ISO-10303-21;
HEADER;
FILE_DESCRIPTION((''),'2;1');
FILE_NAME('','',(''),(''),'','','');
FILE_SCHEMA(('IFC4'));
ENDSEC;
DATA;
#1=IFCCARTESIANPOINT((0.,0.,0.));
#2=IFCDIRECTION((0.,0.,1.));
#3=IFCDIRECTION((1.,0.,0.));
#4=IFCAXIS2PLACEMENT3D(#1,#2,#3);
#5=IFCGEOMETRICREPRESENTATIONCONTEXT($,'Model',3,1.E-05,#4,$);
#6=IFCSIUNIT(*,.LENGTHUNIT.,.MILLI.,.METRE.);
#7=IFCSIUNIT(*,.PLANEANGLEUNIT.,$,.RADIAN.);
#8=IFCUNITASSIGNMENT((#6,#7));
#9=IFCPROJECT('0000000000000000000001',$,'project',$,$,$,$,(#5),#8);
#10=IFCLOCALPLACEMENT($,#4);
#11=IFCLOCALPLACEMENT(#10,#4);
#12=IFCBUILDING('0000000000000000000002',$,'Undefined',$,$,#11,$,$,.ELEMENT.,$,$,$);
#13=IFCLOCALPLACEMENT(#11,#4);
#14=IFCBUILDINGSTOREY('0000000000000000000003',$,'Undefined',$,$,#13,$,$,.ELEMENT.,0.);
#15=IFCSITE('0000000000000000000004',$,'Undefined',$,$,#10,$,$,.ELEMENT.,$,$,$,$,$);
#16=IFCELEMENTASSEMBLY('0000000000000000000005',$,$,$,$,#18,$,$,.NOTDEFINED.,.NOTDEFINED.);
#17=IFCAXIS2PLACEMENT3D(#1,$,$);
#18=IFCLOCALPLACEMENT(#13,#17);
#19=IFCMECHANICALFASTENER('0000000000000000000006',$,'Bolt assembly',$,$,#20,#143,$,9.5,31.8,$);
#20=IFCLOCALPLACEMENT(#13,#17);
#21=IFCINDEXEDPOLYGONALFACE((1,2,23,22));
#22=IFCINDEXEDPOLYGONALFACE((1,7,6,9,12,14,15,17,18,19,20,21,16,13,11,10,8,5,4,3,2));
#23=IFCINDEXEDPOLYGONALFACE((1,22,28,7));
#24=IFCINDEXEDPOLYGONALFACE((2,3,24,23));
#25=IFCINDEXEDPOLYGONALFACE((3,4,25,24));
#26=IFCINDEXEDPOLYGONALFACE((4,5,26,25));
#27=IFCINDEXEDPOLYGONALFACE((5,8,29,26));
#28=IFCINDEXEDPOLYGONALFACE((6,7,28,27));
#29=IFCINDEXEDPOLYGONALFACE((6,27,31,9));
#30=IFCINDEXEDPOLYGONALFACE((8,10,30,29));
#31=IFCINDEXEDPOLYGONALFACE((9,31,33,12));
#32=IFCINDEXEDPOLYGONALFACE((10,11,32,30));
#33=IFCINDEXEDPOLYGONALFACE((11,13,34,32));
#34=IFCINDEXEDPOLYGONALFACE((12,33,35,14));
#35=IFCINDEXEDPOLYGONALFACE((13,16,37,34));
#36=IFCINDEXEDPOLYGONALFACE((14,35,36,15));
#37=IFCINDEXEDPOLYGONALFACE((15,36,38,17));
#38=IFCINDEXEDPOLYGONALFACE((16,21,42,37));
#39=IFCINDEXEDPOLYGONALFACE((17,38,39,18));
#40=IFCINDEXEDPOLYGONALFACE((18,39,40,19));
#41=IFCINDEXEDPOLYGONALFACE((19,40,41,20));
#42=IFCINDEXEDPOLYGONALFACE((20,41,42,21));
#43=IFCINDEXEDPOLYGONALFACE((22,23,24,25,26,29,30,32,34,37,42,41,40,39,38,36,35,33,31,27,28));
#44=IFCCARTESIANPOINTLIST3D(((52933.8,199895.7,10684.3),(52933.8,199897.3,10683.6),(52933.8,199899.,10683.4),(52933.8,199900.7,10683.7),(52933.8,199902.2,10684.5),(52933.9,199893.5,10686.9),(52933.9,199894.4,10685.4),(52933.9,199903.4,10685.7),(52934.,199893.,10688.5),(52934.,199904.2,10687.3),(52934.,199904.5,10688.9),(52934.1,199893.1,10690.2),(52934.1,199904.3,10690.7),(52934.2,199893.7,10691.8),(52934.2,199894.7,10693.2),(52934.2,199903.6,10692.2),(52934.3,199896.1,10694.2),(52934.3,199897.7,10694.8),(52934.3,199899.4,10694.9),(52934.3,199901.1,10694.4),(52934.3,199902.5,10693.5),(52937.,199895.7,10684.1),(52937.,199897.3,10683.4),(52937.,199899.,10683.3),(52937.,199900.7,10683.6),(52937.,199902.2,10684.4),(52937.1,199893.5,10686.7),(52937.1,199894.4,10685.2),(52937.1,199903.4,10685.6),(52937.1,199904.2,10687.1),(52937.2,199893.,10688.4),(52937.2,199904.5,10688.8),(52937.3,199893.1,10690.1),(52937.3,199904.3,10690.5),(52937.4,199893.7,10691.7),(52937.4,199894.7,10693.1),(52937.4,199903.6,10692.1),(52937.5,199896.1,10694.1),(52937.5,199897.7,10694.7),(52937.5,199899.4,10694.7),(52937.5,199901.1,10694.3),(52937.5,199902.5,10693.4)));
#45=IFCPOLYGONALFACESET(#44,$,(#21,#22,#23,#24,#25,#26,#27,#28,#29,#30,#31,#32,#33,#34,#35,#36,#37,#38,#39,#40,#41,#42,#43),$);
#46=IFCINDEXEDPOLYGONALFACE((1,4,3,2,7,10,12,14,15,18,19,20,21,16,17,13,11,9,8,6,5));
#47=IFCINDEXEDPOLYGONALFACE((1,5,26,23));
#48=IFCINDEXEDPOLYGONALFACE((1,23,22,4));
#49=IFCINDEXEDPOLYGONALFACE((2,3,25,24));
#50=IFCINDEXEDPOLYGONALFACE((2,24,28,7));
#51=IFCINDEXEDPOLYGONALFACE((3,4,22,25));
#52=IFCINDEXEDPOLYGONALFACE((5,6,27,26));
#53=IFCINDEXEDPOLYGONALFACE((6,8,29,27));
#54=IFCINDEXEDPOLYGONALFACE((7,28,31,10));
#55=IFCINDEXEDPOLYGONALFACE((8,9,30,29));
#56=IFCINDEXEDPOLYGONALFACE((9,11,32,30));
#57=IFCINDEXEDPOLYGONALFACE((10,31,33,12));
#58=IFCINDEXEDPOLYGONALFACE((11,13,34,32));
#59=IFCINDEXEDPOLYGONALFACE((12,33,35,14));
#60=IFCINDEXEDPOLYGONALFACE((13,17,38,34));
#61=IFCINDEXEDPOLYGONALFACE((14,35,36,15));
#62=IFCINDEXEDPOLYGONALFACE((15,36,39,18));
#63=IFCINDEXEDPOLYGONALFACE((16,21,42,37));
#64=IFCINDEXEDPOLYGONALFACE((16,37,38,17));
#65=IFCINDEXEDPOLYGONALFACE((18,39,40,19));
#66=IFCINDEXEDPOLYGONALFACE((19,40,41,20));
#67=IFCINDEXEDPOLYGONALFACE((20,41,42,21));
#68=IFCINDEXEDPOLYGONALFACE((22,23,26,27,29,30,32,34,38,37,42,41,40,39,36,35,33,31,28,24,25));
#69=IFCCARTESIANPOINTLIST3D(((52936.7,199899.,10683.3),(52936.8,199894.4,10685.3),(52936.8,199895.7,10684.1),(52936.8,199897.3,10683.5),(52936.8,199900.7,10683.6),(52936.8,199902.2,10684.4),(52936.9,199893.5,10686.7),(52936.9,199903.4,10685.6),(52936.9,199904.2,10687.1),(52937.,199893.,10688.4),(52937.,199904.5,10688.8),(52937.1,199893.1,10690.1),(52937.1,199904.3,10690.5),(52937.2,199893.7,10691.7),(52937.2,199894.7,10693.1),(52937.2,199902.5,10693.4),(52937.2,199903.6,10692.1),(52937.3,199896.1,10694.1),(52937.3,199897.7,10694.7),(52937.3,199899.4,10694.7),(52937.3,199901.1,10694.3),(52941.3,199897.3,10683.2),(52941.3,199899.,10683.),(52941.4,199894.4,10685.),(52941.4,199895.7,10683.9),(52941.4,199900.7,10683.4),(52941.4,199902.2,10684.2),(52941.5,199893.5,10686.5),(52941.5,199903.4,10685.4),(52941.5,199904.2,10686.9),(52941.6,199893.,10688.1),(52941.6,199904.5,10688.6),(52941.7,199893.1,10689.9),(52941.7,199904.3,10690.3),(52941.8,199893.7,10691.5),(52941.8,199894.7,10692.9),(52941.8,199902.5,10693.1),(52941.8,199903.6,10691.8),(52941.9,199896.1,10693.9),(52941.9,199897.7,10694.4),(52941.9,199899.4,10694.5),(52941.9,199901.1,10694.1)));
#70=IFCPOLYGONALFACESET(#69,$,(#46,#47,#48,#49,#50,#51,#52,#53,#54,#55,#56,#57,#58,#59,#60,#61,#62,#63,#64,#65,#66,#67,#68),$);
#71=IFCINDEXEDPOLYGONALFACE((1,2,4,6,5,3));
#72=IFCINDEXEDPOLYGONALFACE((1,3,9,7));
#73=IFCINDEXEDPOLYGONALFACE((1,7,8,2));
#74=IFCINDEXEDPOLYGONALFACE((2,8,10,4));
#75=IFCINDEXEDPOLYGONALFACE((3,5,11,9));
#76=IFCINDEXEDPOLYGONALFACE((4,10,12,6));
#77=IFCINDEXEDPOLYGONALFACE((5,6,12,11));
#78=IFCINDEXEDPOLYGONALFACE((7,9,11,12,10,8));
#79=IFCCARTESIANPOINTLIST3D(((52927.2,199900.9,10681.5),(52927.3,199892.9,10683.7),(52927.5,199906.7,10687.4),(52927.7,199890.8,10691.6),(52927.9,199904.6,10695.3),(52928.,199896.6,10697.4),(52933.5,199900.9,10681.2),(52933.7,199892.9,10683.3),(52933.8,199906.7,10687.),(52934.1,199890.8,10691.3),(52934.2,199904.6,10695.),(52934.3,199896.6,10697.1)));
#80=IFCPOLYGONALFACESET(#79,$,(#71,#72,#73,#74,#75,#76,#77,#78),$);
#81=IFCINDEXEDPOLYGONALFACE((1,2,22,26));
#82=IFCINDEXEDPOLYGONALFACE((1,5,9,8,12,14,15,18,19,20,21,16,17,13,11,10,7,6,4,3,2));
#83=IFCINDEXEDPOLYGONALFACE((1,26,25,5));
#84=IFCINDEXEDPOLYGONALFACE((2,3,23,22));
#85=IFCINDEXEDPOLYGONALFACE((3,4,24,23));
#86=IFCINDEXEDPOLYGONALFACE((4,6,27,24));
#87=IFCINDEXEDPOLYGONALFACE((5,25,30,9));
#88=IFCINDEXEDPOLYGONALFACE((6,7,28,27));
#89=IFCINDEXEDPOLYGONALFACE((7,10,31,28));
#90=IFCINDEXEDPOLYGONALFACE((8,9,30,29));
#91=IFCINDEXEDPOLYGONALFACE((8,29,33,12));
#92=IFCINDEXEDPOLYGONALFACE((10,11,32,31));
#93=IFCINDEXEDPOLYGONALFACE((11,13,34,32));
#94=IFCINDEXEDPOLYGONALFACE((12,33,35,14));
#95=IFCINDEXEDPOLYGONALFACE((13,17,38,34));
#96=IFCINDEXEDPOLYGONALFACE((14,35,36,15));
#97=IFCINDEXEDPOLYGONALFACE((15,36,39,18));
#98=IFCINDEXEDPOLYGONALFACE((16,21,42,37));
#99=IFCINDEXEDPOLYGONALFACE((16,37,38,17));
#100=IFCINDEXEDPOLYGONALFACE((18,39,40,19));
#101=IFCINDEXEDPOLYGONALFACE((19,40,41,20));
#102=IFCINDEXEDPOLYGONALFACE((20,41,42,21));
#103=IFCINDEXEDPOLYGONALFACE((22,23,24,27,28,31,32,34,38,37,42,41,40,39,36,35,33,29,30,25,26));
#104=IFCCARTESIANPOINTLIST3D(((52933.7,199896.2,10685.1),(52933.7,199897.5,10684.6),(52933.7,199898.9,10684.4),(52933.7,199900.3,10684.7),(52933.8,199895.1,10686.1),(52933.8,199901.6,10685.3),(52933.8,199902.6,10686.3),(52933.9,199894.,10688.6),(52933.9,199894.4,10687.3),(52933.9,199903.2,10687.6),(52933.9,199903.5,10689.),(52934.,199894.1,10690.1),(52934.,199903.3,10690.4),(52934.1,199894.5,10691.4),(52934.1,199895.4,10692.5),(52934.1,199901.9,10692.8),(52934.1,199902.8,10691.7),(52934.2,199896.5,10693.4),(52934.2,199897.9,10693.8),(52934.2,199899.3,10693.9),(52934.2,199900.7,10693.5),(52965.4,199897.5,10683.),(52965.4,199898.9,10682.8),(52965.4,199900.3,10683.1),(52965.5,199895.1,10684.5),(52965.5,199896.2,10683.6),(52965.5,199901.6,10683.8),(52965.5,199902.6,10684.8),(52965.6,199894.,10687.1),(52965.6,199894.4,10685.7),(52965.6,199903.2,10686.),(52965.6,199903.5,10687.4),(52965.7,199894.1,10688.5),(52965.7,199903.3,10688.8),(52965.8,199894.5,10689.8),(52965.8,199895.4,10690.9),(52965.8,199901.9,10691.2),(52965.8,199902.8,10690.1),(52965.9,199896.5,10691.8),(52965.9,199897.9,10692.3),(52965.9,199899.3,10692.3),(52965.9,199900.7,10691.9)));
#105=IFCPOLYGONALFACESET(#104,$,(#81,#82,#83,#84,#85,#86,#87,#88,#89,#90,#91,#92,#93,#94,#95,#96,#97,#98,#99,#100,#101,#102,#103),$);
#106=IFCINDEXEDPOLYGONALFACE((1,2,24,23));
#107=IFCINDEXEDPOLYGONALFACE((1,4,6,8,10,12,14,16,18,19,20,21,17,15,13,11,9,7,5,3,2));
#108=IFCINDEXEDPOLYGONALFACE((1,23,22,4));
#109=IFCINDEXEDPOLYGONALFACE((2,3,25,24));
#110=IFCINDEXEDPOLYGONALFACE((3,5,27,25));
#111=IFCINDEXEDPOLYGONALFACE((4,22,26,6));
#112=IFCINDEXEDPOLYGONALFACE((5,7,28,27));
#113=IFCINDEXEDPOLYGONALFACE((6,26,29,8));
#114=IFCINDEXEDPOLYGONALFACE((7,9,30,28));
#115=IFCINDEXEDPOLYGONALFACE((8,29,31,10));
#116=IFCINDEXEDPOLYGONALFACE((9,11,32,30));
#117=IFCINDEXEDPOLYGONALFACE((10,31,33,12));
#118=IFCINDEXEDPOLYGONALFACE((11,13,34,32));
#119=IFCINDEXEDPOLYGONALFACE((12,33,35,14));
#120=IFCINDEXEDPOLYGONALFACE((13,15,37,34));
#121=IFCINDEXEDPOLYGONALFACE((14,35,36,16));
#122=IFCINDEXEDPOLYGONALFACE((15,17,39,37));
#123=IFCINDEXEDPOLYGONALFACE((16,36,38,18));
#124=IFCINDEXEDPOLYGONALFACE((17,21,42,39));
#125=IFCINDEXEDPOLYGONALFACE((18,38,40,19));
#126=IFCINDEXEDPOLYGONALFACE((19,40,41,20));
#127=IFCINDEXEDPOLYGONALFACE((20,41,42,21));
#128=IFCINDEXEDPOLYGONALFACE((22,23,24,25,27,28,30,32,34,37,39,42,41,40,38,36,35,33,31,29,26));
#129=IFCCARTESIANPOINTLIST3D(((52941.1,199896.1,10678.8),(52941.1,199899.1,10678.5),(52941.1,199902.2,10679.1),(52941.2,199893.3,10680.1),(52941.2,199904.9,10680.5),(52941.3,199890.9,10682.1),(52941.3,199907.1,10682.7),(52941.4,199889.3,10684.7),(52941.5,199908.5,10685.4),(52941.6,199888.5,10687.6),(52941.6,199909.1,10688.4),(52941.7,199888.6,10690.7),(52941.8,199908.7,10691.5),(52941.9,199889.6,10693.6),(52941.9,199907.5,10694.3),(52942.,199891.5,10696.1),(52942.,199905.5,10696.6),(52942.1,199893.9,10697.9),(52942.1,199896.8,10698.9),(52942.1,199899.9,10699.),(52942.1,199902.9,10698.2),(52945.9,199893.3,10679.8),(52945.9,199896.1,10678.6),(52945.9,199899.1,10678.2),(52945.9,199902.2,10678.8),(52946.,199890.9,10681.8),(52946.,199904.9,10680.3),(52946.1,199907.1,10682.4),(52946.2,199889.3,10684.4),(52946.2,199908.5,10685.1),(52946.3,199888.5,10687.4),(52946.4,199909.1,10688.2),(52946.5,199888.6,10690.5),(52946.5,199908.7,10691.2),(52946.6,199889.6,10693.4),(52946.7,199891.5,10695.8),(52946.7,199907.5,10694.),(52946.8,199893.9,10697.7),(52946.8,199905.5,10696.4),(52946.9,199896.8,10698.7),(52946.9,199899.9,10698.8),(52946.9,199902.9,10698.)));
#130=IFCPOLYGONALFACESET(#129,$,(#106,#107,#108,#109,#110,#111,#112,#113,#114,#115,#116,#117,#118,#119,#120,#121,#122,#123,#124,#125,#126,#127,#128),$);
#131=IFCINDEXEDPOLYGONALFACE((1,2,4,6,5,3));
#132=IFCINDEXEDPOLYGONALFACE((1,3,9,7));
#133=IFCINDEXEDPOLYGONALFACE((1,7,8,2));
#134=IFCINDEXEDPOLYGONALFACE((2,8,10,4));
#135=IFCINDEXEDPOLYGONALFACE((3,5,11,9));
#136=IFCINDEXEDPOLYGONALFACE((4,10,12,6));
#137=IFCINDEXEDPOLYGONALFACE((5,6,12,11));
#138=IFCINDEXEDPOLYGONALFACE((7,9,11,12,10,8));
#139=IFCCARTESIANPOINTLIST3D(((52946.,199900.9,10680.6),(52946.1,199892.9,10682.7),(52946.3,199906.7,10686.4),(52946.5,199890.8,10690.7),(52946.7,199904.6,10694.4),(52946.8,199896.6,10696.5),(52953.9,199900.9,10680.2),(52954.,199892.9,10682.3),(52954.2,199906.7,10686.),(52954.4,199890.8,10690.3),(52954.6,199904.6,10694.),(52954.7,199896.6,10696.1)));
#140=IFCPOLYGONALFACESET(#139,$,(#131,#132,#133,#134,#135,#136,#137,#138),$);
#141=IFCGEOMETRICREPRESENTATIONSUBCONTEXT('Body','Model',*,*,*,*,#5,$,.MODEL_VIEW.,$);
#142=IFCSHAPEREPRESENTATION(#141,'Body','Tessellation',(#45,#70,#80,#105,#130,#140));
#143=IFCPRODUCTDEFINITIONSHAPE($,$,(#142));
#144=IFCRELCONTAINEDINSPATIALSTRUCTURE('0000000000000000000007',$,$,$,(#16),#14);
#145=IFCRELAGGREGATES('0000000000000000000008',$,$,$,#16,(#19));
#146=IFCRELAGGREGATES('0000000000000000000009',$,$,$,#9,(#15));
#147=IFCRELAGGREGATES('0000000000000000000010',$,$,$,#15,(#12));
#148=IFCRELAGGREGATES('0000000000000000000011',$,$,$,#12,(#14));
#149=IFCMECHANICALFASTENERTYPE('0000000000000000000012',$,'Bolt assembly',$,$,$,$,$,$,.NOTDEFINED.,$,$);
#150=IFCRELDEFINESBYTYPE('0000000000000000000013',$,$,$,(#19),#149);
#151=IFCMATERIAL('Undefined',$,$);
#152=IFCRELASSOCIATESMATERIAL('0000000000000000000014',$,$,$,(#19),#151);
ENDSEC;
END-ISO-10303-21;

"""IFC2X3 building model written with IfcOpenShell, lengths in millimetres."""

from ifc_helpers import new_model, si_unit, frame, origin_with_axes, origin_2d_with_axis, place, context, subcontext, project, spatial, polyline, circle, outline, extrude, source, transform, mapped, material, type_object, element, aggregate, save


model = new_model("IFC2X3")

# Units and contexts
model_context = context("Model", 3, precision=1e-05, world=origin_with_axes())
body_context = subcontext(model_context, "Body", "Model", "MODEL_VIEW")
ifc_project = project(units=[si_unit("LENGTHUNIT", "METRE", prefix="MILLI"), si_unit("PLANEANGLEUNIT", "RADIAN")], contexts=[model_context])

# Site, building, storey
site_placement = place(None, origin_with_axes())
site = spatial("IfcSite", under=ifc_project, at=site_placement, Name="Undefined", CompositionType="ELEMENT")
building_placement = place(site_placement, origin_with_axes())
building = spatial("IfcBuilding", under=site, at=building_placement, Name="Undefined", CompositionType="ELEMENT")
storey_placement = place(building_placement, origin_with_axes())
storey = spatial("IfcBuildingStorey", under=building, at=storey_placement, Name="Undefined", CompositionType="ELEMENT", Elevation=0.0)

# Shared definitions
ifc_material_1 = material(Name="Undefined")
mechanical_fastener_type = type_object("IfcMechanicalFastenerType", Name="Bolt assembly")

# Element assembly, mechanical fastener
assembly_1_placement = place(storey_placement, origin_with_axes())
assembly_1 = element("IfcElementAssembly", 1, at=assembly_1_placement, inside=storey, AssemblyPlace="NOTDEFINED", PredefinedType="NOTDEFINED")
shared_shape_1 = source(origin_with_axes(), body_context, "Body", "SweptSolid", [
    extrude(circle(Radius=5.8, at=origin_2d_with_axis()), frame((0.0, -7.6, 0.0), z_axis=(0.0, 1.0, 0.0), x_axis=(1.0, 0.0, 0.0)), (0.0, 0.0, 1.0), 3.2),
    extrude(circle(Radius=5.8, at=origin_2d_with_axis()), frame((0.0, -4.6, 0.0), z_axis=(0.0, 1.0, 0.0), x_axis=(1.0, 0.0, 0.0)), (0.0, 0.0, 1.0), 4.6),
    extrude(outline(polyline([(7.1, -4.1), (7.1, 4.1), (0.0, 8.2), (-7.1, 4.1), (-7.1, -4.1), (0.0, -8.2), (7.1, -4.1)])), frame((0.0, -14.0, 0.0), z_axis=(0.0, 1.0, 0.0), x_axis=(1.0, 0.0, 0.0)), (0.0, 0.0, 1.0), 6.3),
    extrude(circle(Radius=4.8, at=origin_2d_with_axis()), frame((0.0, -7.7, 0.0), z_axis=(0.0, 1.0, 0.0), x_axis=(1.0, 0.0, 0.0)), (0.0, 0.0, 1.0), 31.8),
    extrude(circle(Radius=10.3, at=origin_2d_with_axis()), frame((0.0, 0.0, 0.0), z_axis=(0.0, 1.0, 0.0), x_axis=(1.0, 0.0, 0.0)), (0.0, 0.0, 1.0), 4.8),
    extrude(outline(polyline([(7.1, -4.1), (7.1, 4.1), (0.0, 8.2), (-7.1, 4.1), (-7.1, -4.1), (0.0, -8.2), (7.1, -4.1)])), frame((0.0, 4.8, 0.0), z_axis=(0.0, 1.0, 0.0), x_axis=(1.0, 0.0, 0.0)), (0.0, 0.0, 1.0), 7.9),
])
mechanical_fastener_1_placement = place(assembly_1_placement, frame((52941.6, 199898.8, 10688.8), z_axis=(0.035281, 0.707107, 0.706226), x_axis=(0.035282, -0.707107, 0.706226)))
mechanical_fastener_1 = element("IfcMechanicalFastener", 2, at=mechanical_fastener_1_placement, type_object=mechanical_fastener_type, material=ifc_material_1, Name="Bolt assembly", NominalDiameter=9.5, NominalLength=31.8, context=body_context, shape_type="MappedRepresentation", body=[
    mapped(shared_shape_1, transform((0.0, 0.0, 0.0))),
])
aggregate(assembly_1, [mechanical_fastener_1])

save(model, "model.ifc")
